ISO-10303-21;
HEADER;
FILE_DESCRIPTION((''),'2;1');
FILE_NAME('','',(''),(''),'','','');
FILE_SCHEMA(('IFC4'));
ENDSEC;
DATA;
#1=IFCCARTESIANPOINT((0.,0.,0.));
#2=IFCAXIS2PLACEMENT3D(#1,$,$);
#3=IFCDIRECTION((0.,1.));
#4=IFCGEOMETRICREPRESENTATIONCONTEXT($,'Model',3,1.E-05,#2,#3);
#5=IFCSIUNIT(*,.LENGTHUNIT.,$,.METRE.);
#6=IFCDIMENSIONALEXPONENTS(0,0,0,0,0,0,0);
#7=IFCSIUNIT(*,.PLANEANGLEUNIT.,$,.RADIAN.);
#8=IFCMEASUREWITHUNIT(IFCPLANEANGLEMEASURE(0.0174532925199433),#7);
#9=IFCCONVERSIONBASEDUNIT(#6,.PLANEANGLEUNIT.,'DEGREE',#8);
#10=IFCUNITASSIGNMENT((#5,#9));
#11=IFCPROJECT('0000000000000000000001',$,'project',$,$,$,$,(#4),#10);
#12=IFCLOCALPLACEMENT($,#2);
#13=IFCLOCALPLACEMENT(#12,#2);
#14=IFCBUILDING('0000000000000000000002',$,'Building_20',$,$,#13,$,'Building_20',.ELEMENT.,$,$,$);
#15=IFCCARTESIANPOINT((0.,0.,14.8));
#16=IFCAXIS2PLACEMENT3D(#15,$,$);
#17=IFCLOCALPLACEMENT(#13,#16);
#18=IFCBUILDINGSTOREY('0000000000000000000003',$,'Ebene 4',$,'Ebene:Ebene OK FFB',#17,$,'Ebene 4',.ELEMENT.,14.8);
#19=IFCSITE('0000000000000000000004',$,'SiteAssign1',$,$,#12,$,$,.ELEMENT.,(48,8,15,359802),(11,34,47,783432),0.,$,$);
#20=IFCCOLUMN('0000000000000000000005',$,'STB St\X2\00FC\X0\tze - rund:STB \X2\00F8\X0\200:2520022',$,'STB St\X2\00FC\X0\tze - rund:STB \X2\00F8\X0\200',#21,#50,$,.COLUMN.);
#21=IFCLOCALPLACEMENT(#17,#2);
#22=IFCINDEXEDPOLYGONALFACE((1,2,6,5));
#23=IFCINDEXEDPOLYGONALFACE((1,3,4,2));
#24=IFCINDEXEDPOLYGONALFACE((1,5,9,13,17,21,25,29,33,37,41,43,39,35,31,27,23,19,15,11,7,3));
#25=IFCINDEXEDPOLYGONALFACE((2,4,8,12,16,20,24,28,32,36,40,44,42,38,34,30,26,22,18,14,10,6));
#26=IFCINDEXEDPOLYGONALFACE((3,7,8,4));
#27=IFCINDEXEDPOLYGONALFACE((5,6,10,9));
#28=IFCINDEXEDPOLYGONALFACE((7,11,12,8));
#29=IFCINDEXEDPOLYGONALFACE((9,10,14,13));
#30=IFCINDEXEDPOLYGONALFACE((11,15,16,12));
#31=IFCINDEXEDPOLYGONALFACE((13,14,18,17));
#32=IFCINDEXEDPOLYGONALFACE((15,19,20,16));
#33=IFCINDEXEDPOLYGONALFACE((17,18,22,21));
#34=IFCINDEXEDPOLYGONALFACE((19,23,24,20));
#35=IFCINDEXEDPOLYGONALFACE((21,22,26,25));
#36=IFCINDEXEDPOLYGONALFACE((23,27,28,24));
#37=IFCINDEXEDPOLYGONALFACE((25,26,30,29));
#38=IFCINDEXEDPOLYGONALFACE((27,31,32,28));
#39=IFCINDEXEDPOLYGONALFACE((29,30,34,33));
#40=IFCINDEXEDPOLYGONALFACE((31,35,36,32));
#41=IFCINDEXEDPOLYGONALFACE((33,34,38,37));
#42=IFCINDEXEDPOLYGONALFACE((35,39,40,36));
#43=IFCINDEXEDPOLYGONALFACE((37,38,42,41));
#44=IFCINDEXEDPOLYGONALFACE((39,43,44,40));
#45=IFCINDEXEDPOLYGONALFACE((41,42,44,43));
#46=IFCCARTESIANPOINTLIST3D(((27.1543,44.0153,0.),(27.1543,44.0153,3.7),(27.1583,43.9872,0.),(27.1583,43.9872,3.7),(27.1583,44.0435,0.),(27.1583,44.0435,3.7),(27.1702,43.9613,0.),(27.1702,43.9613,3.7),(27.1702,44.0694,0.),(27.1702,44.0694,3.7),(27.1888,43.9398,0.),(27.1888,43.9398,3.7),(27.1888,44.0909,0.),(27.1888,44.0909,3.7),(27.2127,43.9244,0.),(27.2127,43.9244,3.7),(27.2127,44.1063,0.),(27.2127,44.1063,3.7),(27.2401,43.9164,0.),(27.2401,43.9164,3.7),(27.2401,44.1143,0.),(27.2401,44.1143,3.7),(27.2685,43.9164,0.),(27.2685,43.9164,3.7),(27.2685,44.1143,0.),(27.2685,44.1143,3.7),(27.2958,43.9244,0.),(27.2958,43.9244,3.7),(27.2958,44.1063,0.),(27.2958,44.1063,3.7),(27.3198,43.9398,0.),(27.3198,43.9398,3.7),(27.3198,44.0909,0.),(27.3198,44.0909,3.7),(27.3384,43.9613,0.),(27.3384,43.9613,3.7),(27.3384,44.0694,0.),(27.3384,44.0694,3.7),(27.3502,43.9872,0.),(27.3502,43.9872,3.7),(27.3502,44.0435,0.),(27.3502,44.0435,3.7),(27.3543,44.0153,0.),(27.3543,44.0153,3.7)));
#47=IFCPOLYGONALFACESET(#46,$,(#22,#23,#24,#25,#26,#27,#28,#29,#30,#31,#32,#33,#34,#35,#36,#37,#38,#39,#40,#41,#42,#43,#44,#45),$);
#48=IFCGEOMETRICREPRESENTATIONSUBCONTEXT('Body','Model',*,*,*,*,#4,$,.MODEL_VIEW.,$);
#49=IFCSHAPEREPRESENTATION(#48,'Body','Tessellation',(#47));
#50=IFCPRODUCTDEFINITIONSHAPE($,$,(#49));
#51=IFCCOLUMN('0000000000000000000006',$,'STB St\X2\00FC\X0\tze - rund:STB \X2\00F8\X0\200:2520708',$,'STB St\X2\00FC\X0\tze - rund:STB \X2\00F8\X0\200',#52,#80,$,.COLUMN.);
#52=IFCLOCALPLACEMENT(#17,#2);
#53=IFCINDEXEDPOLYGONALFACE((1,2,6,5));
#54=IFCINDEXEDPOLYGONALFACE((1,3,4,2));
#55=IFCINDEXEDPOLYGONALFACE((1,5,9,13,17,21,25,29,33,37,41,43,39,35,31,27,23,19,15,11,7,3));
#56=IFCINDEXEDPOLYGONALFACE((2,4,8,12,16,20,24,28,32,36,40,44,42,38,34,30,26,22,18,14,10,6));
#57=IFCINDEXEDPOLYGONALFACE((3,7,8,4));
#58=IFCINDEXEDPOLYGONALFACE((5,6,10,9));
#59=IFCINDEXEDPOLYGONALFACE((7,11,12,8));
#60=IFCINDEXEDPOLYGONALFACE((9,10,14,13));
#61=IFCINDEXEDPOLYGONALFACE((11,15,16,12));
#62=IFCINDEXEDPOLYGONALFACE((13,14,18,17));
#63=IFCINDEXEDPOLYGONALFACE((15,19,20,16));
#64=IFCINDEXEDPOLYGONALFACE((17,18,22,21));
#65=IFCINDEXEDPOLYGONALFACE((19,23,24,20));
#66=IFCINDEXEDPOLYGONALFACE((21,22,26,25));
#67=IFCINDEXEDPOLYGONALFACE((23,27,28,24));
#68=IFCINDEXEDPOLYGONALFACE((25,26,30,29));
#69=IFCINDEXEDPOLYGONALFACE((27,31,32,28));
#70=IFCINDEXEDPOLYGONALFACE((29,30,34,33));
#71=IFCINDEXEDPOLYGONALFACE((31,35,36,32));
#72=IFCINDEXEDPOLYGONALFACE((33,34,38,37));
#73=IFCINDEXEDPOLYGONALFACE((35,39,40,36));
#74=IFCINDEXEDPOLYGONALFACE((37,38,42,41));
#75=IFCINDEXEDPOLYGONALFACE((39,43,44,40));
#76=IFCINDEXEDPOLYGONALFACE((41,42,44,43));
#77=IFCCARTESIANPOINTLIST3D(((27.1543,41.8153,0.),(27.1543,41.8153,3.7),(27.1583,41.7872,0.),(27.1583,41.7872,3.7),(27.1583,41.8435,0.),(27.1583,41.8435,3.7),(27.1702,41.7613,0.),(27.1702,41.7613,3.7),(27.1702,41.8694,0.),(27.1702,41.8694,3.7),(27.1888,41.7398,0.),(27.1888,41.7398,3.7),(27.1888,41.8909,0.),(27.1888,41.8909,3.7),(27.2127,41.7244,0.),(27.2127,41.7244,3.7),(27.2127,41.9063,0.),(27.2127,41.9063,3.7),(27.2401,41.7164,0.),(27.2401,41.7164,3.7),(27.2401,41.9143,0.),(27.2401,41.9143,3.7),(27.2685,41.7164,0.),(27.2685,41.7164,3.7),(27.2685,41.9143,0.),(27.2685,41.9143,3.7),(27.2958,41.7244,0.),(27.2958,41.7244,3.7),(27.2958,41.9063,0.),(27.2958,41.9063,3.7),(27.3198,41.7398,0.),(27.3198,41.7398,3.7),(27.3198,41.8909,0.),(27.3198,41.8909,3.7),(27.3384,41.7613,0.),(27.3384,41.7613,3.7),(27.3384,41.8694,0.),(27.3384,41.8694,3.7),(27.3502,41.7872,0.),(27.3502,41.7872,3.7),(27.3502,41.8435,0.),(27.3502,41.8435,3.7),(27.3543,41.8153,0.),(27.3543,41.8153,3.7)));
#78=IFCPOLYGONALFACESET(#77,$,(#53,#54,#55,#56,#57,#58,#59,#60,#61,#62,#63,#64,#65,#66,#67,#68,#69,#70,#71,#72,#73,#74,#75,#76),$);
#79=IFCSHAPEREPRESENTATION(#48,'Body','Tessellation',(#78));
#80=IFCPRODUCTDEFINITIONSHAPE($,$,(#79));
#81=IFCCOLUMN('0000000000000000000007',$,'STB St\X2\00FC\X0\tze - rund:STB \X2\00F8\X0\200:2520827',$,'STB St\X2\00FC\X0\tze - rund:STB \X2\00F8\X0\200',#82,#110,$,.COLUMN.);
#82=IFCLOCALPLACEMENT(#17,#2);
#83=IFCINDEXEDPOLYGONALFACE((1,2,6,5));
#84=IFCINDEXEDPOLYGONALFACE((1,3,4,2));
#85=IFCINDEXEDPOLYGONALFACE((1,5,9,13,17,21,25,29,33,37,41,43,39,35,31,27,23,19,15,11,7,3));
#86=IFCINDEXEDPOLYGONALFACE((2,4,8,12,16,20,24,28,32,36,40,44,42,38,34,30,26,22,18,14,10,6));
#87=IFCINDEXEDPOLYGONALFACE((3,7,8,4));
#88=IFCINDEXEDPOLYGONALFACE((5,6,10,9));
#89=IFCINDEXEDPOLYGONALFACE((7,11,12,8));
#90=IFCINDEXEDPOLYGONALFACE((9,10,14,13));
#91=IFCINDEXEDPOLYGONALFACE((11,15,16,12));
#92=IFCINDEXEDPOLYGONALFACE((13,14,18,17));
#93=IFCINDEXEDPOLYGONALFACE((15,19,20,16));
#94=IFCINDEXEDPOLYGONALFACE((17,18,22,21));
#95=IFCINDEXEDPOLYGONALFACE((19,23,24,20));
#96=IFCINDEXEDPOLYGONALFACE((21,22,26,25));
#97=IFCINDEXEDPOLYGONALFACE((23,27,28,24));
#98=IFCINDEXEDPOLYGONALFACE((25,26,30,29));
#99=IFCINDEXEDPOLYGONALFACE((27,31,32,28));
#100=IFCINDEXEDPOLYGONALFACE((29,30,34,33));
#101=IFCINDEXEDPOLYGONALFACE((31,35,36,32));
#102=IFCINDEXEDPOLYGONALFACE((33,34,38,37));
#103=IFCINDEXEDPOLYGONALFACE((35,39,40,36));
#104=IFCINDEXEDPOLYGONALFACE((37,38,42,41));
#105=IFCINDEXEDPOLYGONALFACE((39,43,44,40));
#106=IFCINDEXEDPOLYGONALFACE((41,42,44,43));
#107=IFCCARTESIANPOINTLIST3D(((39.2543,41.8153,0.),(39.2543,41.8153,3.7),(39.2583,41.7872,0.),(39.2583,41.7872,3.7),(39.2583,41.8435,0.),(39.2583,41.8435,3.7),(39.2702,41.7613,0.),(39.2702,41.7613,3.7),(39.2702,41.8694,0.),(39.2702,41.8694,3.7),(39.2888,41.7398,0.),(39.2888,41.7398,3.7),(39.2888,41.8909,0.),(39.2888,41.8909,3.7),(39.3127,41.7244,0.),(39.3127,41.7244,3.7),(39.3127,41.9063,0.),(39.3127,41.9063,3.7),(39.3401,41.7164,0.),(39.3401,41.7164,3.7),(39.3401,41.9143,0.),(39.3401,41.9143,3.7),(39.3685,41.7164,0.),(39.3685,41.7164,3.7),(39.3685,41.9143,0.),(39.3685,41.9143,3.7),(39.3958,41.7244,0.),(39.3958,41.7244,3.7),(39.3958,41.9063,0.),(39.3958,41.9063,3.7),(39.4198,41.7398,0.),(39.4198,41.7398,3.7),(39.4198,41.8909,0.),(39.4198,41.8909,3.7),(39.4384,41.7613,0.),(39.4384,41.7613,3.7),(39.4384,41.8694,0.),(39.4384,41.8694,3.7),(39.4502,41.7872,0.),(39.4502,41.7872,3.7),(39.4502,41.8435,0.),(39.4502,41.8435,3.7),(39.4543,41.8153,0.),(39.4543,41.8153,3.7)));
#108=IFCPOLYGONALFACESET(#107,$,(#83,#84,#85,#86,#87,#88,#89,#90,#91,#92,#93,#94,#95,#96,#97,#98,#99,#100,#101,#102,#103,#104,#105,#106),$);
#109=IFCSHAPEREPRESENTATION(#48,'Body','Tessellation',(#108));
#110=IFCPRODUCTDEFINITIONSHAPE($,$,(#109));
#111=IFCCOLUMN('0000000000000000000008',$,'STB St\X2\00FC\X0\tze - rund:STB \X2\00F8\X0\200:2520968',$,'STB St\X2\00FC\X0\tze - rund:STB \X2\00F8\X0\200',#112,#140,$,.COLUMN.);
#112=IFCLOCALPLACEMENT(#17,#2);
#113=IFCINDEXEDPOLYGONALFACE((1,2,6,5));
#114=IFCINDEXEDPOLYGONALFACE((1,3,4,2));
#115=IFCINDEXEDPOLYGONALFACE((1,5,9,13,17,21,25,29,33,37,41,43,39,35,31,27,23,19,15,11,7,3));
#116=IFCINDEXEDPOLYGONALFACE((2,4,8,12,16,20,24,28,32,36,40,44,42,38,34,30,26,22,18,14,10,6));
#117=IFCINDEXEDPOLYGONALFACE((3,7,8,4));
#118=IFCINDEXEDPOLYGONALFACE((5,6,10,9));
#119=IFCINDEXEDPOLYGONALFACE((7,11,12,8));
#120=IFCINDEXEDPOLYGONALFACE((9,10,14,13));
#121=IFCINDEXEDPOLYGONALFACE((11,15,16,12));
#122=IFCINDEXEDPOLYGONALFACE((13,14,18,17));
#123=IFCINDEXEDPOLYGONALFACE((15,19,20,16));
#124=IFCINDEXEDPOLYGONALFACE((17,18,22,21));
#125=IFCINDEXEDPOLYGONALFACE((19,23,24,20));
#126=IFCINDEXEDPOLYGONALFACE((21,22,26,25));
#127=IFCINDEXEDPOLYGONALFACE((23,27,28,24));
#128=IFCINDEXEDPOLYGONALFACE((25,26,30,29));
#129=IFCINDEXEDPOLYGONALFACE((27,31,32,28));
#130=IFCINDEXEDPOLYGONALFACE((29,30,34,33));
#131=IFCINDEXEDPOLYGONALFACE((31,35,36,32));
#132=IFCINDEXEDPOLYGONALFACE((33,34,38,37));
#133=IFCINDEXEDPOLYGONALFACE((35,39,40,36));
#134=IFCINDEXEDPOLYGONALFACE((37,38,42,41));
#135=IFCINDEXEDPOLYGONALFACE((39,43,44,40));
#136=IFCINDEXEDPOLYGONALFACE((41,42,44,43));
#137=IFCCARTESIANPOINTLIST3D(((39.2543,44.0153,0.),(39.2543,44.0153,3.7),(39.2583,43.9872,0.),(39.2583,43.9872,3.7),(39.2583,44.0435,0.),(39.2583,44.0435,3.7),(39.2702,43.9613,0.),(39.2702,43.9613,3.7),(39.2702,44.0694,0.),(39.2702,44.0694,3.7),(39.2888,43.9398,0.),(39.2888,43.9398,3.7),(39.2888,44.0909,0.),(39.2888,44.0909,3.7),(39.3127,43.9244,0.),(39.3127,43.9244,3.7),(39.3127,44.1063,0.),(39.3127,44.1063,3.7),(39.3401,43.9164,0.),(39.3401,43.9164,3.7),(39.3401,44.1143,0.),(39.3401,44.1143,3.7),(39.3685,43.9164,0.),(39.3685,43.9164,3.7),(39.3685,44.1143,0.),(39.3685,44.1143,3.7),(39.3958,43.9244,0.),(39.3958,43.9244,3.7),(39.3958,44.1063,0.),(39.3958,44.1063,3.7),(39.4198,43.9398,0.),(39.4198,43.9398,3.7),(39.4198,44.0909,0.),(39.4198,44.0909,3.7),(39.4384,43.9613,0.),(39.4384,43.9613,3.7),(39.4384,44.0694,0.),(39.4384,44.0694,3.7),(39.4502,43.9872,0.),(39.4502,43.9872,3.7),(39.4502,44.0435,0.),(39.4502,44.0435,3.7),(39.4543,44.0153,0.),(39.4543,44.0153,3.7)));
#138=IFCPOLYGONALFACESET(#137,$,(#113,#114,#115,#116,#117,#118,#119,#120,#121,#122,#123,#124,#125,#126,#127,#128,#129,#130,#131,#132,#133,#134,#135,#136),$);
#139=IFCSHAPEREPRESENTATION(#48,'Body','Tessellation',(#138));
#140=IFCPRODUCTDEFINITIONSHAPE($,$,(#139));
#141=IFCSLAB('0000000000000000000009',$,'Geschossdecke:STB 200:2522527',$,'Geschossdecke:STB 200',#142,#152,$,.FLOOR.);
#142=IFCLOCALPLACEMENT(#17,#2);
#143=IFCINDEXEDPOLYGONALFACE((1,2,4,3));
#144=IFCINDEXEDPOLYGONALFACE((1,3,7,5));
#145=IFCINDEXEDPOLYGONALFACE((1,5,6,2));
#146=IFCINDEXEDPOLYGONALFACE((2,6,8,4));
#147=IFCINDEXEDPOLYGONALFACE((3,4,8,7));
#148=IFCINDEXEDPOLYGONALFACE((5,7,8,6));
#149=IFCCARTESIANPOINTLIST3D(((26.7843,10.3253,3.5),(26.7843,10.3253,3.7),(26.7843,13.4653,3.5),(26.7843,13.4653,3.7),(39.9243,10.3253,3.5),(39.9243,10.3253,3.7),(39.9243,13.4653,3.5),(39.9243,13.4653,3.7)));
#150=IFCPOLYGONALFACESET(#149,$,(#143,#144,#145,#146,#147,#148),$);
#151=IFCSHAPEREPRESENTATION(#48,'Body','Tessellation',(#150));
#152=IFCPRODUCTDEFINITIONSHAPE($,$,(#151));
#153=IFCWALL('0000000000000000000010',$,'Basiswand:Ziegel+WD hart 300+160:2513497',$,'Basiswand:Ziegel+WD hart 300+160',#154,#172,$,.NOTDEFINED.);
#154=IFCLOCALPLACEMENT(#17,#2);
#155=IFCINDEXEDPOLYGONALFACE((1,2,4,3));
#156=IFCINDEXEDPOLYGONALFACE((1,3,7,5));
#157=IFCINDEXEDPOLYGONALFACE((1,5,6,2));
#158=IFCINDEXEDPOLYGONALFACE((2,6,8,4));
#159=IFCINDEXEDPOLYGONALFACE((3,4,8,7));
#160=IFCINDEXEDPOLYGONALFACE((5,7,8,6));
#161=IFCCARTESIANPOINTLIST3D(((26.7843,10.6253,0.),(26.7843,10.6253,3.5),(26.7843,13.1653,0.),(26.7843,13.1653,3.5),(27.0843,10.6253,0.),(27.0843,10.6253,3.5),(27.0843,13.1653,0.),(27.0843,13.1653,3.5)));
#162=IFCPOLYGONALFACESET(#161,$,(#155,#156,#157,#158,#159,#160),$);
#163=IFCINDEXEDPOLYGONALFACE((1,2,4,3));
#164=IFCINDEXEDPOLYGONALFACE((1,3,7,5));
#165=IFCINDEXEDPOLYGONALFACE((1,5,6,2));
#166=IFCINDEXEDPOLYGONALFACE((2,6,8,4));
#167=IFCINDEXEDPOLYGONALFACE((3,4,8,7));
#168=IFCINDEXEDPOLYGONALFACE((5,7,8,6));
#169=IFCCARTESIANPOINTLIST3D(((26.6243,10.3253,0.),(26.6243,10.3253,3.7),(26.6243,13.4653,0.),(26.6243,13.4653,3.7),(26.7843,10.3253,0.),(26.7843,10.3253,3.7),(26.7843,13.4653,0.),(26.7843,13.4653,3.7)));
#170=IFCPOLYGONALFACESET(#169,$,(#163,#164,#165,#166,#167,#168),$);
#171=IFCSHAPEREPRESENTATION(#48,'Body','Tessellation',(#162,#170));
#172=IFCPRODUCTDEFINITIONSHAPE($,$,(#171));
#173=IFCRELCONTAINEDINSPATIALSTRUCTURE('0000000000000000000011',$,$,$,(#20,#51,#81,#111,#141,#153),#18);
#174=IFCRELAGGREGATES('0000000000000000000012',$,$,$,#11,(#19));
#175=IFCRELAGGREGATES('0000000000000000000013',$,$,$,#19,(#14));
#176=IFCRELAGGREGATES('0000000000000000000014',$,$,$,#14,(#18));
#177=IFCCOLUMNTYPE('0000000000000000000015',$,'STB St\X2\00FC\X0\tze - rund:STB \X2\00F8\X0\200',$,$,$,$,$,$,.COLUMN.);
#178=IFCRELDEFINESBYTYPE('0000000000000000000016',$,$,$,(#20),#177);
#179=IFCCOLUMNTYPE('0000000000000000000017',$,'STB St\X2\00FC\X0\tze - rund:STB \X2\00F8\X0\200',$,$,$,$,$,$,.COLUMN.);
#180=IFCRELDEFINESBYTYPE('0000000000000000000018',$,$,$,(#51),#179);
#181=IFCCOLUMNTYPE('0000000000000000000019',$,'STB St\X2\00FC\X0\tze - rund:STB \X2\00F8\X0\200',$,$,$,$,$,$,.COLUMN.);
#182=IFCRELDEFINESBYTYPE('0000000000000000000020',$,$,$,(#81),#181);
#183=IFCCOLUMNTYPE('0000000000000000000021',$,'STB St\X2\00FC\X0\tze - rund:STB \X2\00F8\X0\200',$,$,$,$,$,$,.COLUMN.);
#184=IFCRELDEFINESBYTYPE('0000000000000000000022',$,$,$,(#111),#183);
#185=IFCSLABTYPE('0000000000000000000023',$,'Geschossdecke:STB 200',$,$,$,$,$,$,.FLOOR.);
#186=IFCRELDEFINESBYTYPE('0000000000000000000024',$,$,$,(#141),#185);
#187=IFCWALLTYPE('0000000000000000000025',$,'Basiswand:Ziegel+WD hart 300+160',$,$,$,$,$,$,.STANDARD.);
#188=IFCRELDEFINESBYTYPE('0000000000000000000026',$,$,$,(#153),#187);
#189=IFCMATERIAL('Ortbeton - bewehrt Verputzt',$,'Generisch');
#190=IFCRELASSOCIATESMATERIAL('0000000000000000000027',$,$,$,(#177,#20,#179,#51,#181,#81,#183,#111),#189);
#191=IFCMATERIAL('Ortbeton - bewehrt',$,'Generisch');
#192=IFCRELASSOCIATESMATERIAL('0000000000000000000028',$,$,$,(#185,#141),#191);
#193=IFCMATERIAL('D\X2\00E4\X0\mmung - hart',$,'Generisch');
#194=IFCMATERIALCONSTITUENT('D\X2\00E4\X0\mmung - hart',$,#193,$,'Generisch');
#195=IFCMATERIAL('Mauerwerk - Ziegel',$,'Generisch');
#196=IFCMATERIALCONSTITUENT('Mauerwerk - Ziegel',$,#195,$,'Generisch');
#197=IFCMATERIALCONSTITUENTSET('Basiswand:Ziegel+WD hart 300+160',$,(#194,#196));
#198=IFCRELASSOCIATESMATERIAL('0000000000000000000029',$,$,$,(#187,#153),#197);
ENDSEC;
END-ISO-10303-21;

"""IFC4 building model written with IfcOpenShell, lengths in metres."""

from ifc_helpers import new_model, entity, si_unit, converted_unit, direction, frame, origin, place, context, subcontext, project, spatial, arc, indexed_curve, outline, extrude, source, transform, mapped, material, constituent, constituent_set, type_object, type_shapes, element, save


model = new_model("IFC4")

# Units and contexts
model_context = context("Model", 3, precision=1e-05, world=origin(), true_north=direction((0.0, 1.0)))
body_context = subcontext(model_context, "Body", "Model", "MODEL_VIEW")
ifc_project = project(units=[si_unit("LENGTHUNIT", "METRE"), converted_unit("PLANEANGLEUNIT", "DEGREE", entity("IfcPlaneAngleMeasure", 0.0174532925199433), si_unit("PLANEANGLEUNIT", "RADIAN"), dimensions=[0, 0, 0, 0, 0, 0, 0])], contexts=[model_context])

# Site, building, storey
site_placement = place(None, origin())
site = spatial("IfcSite", under=ifc_project, at=site_placement, Name="SiteAssign1", CompositionType="ELEMENT", RefLatitude=(48, 8, 15, 359802), RefLongitude=(11, 34, 47, 783432), RefElevation=0.0)
building_placement = place(site_placement, origin())
building = spatial("IfcBuilding", under=site, at=building_placement, Name="Building_20", LongName="Building_20", CompositionType="ELEMENT")
storey_placement = place(building_placement, frame((0.0, 0.0, 14.8)))
storey = spatial("IfcBuildingStorey", under=building, at=storey_placement, Name="Ebene 4", ObjectType="Ebene:Ebene OK FFB", LongName="Ebene 4", CompositionType="ELEMENT", Elevation=14.8)

# Columns
ifc_material_1 = material(Name="Ortbeton - bewehrt Verputzt", Category="Generisch")
column_type_1 = type_object("IfcColumnType", Name="STB Stütze - rund:STB ø200", PredefinedType="COLUMN", material=ifc_material_1)
shared_shape_1 = source(origin(), body_context, "Body", "SweptSolid", [
    extrude(outline(indexed_curve([(-0.1, 0.0), (0.0, -0.1), (0.1, 0.0), (0.0, 0.1)], segments=[arc(1, 2, 3), arc(3, 4, 1)], self_intersect=False)), frame((27.2543, 44.0153, 14.8)), (0.0, 0.0, 1.0), 3.7),
])
type_shapes(column_type_1, [shared_shape_1])
column_1_placement = place(storey_placement, frame((0.0, 0.0, -14.8)))
element("IfcColumn", 1, at=column_1_placement, inside=storey, type_object=column_type_1, material=ifc_material_1, Name="STB Stütze - rund:STB ø200:2520022", ObjectType="STB Stütze - rund:STB ø200", PredefinedType="COLUMN", context=body_context, shape_type="MappedRepresentation", body=[
    mapped(shared_shape_1, transform((0.0, 0.0, 0.0), scale=1.0)),
])
column_type_2 = type_object("IfcColumnType", Name="STB Stütze - rund:STB ø200", PredefinedType="COLUMN", material=ifc_material_1)
shared_shape_2 = source(origin(), body_context, "Body", "SweptSolid", [
    extrude(outline(indexed_curve([(-0.1, 0.0), (0.0, -0.1), (0.1, 0.0), (0.0, 0.1)], segments=[arc(1, 2, 3), arc(3, 4, 1)], self_intersect=False)), frame((27.2543, 41.8153, 14.8)), (0.0, 0.0, 1.0), 3.7),
])
type_shapes(column_type_2, [shared_shape_2])
column_2_placement = place(storey_placement, frame((0.0, 0.0, -14.8)))
element("IfcColumn", 2, at=column_2_placement, inside=storey, type_object=column_type_2, material=ifc_material_1, Name="STB Stütze - rund:STB ø200:2520708", ObjectType="STB Stütze - rund:STB ø200", PredefinedType="COLUMN", context=body_context, shape_type="MappedRepresentation", body=[
    mapped(shared_shape_2, transform((0.0, 0.0, 0.0), scale=1.0)),
])
column_type_3 = type_object("IfcColumnType", Name="STB Stütze - rund:STB ø200", PredefinedType="COLUMN", material=ifc_material_1)
shared_shape_3 = source(origin(), body_context, "Body", "SweptSolid", [
    extrude(outline(indexed_curve([(-0.1, 0.0), (0.0, -0.1), (0.1, 0.0), (0.0, 0.1)], segments=[arc(1, 2, 3), arc(3, 4, 1)], self_intersect=False)), frame((39.3543, 41.8153, 14.8)), (0.0, 0.0, 1.0), 3.7),
])
type_shapes(column_type_3, [shared_shape_3])
column_3_placement = place(storey_placement, frame((0.0, 0.0, -14.8)))
element("IfcColumn", 3, at=column_3_placement, inside=storey, type_object=column_type_3, material=ifc_material_1, Name="STB Stütze - rund:STB ø200:2520827", ObjectType="STB Stütze - rund:STB ø200", PredefinedType="COLUMN", context=body_context, shape_type="MappedRepresentation", body=[
    mapped(shared_shape_3, transform((0.0, 0.0, 0.0), scale=1.0)),
])
column_type_4 = type_object("IfcColumnType", Name="STB Stütze - rund:STB ø200", PredefinedType="COLUMN", material=ifc_material_1)
shared_shape_4 = source(origin(), body_context, "Body", "SweptSolid", [
    extrude(outline(indexed_curve([(-0.1, 0.0), (0.0, -0.1), (0.1, 0.0), (0.0, 0.1)], segments=[arc(1, 2, 3), arc(3, 4, 1)], self_intersect=False)), frame((39.3543, 44.0153, 14.8)), (0.0, 0.0, 1.0), 3.7),
])
type_shapes(column_type_4, [shared_shape_4])
column_4_placement = place(storey_placement, frame((0.0, 0.0, -14.8)))
element("IfcColumn", 4, at=column_4_placement, inside=storey, type_object=column_type_4, material=ifc_material_1, Name="STB Stütze - rund:STB ø200:2520968", ObjectType="STB Stütze - rund:STB ø200", PredefinedType="COLUMN", context=body_context, shape_type="MappedRepresentation", body=[
    mapped(shared_shape_4, transform((0.0, 0.0, 0.0), scale=1.0)),
])

# Shared definitions
ifc_material_2 = material(Name="Ortbeton - bewehrt", Category="Generisch")
slab_type = type_object("IfcSlabType", Name="Geschossdecke:STB 200", PredefinedType="FLOOR", material=ifc_material_2)

# Slab
slab_1_placement = place(storey_placement, origin())
element("IfcSlab", 5, at=slab_1_placement, inside=storey, type_object=slab_type, material=ifc_material_2, Name="Geschossdecke:STB 200:2522527", ObjectType="Geschossdecke:STB 200", PredefinedType="FLOOR", context=body_context, shape_type="SweptSolid", body=[
    extrude(outline(indexed_curve([(-1.57, -6.57), (1.57, -6.57), (1.57, 6.57), (-1.57, 6.57), (-1.57, -6.57)], self_intersect=False)), frame((33.3543, 11.8953, 3.7), z_axis=(0.0, 0.0, -1.0), x_axis=(0.0, 1.0, 0.0)), (0.0, 0.0, 1.0), 0.2),
])

# Wall
ifc_material_3 = material(Name="Dämmung - hart", Category="Generisch")
ifc_constituent_1 = constituent(ifc_material_3, Name="Dämmung - hart", Category="Generisch")
ifc_material_4 = material(Name="Mauerwerk - Ziegel", Category="Generisch")
ifc_constituent_2 = constituent(ifc_material_4, Name="Mauerwerk - Ziegel", Category="Generisch")
ifc_constituent_set = constituent_set(constituents=[ifc_constituent_1, ifc_constituent_2], Name="Basiswand:Ziegel+WD hart 300+160")
wall_type = type_object("IfcWallType", Name="Basiswand:Ziegel+WD hart 300+160", PredefinedType="STANDARD", material=ifc_constituent_set)
wall_placement = place(storey_placement, frame((26.8543, 10.6253, 0.0), z_axis=(0.0, 0.0, 1.0), x_axis=(0.0, 1.0, 0.0)))
element("IfcWall", 6, at=wall_placement, inside=storey, type_object=wall_type, material=ifc_constituent_set, Name="Basiswand:Ziegel+WD hart 300+160:2513497", ObjectType="Basiswand:Ziegel+WD hart 300+160", PredefinedType="NOTDEFINED", context=body_context, shape_type="SweptSolid", body=[
    extrude(outline(indexed_curve([(-1.75, -1.27), (1.75, -1.27), (1.75, 1.27), (-1.75, 1.27), (-1.75, -1.27)], self_intersect=False)), frame((1.27, 0.07, 1.75), z_axis=(0.0, -1.0, 0.0), x_axis=(0.0, 0.0, 1.0)), (0.0, 0.0, 1.0), 0.3),
    extrude(outline(indexed_curve([(-0.08, -1.57), (0.08, -1.57), (0.08, 1.57), (-0.08, 1.57), (-0.08, -1.57)], self_intersect=False)), frame((1.27, 0.15, 0.0), z_axis=(0.0, 0.0, 1.0), x_axis=(0.0, -1.0, 0.0)), (0.0, 0.0, 1.0), 3.7),
])

save(model, "model.ifc")
